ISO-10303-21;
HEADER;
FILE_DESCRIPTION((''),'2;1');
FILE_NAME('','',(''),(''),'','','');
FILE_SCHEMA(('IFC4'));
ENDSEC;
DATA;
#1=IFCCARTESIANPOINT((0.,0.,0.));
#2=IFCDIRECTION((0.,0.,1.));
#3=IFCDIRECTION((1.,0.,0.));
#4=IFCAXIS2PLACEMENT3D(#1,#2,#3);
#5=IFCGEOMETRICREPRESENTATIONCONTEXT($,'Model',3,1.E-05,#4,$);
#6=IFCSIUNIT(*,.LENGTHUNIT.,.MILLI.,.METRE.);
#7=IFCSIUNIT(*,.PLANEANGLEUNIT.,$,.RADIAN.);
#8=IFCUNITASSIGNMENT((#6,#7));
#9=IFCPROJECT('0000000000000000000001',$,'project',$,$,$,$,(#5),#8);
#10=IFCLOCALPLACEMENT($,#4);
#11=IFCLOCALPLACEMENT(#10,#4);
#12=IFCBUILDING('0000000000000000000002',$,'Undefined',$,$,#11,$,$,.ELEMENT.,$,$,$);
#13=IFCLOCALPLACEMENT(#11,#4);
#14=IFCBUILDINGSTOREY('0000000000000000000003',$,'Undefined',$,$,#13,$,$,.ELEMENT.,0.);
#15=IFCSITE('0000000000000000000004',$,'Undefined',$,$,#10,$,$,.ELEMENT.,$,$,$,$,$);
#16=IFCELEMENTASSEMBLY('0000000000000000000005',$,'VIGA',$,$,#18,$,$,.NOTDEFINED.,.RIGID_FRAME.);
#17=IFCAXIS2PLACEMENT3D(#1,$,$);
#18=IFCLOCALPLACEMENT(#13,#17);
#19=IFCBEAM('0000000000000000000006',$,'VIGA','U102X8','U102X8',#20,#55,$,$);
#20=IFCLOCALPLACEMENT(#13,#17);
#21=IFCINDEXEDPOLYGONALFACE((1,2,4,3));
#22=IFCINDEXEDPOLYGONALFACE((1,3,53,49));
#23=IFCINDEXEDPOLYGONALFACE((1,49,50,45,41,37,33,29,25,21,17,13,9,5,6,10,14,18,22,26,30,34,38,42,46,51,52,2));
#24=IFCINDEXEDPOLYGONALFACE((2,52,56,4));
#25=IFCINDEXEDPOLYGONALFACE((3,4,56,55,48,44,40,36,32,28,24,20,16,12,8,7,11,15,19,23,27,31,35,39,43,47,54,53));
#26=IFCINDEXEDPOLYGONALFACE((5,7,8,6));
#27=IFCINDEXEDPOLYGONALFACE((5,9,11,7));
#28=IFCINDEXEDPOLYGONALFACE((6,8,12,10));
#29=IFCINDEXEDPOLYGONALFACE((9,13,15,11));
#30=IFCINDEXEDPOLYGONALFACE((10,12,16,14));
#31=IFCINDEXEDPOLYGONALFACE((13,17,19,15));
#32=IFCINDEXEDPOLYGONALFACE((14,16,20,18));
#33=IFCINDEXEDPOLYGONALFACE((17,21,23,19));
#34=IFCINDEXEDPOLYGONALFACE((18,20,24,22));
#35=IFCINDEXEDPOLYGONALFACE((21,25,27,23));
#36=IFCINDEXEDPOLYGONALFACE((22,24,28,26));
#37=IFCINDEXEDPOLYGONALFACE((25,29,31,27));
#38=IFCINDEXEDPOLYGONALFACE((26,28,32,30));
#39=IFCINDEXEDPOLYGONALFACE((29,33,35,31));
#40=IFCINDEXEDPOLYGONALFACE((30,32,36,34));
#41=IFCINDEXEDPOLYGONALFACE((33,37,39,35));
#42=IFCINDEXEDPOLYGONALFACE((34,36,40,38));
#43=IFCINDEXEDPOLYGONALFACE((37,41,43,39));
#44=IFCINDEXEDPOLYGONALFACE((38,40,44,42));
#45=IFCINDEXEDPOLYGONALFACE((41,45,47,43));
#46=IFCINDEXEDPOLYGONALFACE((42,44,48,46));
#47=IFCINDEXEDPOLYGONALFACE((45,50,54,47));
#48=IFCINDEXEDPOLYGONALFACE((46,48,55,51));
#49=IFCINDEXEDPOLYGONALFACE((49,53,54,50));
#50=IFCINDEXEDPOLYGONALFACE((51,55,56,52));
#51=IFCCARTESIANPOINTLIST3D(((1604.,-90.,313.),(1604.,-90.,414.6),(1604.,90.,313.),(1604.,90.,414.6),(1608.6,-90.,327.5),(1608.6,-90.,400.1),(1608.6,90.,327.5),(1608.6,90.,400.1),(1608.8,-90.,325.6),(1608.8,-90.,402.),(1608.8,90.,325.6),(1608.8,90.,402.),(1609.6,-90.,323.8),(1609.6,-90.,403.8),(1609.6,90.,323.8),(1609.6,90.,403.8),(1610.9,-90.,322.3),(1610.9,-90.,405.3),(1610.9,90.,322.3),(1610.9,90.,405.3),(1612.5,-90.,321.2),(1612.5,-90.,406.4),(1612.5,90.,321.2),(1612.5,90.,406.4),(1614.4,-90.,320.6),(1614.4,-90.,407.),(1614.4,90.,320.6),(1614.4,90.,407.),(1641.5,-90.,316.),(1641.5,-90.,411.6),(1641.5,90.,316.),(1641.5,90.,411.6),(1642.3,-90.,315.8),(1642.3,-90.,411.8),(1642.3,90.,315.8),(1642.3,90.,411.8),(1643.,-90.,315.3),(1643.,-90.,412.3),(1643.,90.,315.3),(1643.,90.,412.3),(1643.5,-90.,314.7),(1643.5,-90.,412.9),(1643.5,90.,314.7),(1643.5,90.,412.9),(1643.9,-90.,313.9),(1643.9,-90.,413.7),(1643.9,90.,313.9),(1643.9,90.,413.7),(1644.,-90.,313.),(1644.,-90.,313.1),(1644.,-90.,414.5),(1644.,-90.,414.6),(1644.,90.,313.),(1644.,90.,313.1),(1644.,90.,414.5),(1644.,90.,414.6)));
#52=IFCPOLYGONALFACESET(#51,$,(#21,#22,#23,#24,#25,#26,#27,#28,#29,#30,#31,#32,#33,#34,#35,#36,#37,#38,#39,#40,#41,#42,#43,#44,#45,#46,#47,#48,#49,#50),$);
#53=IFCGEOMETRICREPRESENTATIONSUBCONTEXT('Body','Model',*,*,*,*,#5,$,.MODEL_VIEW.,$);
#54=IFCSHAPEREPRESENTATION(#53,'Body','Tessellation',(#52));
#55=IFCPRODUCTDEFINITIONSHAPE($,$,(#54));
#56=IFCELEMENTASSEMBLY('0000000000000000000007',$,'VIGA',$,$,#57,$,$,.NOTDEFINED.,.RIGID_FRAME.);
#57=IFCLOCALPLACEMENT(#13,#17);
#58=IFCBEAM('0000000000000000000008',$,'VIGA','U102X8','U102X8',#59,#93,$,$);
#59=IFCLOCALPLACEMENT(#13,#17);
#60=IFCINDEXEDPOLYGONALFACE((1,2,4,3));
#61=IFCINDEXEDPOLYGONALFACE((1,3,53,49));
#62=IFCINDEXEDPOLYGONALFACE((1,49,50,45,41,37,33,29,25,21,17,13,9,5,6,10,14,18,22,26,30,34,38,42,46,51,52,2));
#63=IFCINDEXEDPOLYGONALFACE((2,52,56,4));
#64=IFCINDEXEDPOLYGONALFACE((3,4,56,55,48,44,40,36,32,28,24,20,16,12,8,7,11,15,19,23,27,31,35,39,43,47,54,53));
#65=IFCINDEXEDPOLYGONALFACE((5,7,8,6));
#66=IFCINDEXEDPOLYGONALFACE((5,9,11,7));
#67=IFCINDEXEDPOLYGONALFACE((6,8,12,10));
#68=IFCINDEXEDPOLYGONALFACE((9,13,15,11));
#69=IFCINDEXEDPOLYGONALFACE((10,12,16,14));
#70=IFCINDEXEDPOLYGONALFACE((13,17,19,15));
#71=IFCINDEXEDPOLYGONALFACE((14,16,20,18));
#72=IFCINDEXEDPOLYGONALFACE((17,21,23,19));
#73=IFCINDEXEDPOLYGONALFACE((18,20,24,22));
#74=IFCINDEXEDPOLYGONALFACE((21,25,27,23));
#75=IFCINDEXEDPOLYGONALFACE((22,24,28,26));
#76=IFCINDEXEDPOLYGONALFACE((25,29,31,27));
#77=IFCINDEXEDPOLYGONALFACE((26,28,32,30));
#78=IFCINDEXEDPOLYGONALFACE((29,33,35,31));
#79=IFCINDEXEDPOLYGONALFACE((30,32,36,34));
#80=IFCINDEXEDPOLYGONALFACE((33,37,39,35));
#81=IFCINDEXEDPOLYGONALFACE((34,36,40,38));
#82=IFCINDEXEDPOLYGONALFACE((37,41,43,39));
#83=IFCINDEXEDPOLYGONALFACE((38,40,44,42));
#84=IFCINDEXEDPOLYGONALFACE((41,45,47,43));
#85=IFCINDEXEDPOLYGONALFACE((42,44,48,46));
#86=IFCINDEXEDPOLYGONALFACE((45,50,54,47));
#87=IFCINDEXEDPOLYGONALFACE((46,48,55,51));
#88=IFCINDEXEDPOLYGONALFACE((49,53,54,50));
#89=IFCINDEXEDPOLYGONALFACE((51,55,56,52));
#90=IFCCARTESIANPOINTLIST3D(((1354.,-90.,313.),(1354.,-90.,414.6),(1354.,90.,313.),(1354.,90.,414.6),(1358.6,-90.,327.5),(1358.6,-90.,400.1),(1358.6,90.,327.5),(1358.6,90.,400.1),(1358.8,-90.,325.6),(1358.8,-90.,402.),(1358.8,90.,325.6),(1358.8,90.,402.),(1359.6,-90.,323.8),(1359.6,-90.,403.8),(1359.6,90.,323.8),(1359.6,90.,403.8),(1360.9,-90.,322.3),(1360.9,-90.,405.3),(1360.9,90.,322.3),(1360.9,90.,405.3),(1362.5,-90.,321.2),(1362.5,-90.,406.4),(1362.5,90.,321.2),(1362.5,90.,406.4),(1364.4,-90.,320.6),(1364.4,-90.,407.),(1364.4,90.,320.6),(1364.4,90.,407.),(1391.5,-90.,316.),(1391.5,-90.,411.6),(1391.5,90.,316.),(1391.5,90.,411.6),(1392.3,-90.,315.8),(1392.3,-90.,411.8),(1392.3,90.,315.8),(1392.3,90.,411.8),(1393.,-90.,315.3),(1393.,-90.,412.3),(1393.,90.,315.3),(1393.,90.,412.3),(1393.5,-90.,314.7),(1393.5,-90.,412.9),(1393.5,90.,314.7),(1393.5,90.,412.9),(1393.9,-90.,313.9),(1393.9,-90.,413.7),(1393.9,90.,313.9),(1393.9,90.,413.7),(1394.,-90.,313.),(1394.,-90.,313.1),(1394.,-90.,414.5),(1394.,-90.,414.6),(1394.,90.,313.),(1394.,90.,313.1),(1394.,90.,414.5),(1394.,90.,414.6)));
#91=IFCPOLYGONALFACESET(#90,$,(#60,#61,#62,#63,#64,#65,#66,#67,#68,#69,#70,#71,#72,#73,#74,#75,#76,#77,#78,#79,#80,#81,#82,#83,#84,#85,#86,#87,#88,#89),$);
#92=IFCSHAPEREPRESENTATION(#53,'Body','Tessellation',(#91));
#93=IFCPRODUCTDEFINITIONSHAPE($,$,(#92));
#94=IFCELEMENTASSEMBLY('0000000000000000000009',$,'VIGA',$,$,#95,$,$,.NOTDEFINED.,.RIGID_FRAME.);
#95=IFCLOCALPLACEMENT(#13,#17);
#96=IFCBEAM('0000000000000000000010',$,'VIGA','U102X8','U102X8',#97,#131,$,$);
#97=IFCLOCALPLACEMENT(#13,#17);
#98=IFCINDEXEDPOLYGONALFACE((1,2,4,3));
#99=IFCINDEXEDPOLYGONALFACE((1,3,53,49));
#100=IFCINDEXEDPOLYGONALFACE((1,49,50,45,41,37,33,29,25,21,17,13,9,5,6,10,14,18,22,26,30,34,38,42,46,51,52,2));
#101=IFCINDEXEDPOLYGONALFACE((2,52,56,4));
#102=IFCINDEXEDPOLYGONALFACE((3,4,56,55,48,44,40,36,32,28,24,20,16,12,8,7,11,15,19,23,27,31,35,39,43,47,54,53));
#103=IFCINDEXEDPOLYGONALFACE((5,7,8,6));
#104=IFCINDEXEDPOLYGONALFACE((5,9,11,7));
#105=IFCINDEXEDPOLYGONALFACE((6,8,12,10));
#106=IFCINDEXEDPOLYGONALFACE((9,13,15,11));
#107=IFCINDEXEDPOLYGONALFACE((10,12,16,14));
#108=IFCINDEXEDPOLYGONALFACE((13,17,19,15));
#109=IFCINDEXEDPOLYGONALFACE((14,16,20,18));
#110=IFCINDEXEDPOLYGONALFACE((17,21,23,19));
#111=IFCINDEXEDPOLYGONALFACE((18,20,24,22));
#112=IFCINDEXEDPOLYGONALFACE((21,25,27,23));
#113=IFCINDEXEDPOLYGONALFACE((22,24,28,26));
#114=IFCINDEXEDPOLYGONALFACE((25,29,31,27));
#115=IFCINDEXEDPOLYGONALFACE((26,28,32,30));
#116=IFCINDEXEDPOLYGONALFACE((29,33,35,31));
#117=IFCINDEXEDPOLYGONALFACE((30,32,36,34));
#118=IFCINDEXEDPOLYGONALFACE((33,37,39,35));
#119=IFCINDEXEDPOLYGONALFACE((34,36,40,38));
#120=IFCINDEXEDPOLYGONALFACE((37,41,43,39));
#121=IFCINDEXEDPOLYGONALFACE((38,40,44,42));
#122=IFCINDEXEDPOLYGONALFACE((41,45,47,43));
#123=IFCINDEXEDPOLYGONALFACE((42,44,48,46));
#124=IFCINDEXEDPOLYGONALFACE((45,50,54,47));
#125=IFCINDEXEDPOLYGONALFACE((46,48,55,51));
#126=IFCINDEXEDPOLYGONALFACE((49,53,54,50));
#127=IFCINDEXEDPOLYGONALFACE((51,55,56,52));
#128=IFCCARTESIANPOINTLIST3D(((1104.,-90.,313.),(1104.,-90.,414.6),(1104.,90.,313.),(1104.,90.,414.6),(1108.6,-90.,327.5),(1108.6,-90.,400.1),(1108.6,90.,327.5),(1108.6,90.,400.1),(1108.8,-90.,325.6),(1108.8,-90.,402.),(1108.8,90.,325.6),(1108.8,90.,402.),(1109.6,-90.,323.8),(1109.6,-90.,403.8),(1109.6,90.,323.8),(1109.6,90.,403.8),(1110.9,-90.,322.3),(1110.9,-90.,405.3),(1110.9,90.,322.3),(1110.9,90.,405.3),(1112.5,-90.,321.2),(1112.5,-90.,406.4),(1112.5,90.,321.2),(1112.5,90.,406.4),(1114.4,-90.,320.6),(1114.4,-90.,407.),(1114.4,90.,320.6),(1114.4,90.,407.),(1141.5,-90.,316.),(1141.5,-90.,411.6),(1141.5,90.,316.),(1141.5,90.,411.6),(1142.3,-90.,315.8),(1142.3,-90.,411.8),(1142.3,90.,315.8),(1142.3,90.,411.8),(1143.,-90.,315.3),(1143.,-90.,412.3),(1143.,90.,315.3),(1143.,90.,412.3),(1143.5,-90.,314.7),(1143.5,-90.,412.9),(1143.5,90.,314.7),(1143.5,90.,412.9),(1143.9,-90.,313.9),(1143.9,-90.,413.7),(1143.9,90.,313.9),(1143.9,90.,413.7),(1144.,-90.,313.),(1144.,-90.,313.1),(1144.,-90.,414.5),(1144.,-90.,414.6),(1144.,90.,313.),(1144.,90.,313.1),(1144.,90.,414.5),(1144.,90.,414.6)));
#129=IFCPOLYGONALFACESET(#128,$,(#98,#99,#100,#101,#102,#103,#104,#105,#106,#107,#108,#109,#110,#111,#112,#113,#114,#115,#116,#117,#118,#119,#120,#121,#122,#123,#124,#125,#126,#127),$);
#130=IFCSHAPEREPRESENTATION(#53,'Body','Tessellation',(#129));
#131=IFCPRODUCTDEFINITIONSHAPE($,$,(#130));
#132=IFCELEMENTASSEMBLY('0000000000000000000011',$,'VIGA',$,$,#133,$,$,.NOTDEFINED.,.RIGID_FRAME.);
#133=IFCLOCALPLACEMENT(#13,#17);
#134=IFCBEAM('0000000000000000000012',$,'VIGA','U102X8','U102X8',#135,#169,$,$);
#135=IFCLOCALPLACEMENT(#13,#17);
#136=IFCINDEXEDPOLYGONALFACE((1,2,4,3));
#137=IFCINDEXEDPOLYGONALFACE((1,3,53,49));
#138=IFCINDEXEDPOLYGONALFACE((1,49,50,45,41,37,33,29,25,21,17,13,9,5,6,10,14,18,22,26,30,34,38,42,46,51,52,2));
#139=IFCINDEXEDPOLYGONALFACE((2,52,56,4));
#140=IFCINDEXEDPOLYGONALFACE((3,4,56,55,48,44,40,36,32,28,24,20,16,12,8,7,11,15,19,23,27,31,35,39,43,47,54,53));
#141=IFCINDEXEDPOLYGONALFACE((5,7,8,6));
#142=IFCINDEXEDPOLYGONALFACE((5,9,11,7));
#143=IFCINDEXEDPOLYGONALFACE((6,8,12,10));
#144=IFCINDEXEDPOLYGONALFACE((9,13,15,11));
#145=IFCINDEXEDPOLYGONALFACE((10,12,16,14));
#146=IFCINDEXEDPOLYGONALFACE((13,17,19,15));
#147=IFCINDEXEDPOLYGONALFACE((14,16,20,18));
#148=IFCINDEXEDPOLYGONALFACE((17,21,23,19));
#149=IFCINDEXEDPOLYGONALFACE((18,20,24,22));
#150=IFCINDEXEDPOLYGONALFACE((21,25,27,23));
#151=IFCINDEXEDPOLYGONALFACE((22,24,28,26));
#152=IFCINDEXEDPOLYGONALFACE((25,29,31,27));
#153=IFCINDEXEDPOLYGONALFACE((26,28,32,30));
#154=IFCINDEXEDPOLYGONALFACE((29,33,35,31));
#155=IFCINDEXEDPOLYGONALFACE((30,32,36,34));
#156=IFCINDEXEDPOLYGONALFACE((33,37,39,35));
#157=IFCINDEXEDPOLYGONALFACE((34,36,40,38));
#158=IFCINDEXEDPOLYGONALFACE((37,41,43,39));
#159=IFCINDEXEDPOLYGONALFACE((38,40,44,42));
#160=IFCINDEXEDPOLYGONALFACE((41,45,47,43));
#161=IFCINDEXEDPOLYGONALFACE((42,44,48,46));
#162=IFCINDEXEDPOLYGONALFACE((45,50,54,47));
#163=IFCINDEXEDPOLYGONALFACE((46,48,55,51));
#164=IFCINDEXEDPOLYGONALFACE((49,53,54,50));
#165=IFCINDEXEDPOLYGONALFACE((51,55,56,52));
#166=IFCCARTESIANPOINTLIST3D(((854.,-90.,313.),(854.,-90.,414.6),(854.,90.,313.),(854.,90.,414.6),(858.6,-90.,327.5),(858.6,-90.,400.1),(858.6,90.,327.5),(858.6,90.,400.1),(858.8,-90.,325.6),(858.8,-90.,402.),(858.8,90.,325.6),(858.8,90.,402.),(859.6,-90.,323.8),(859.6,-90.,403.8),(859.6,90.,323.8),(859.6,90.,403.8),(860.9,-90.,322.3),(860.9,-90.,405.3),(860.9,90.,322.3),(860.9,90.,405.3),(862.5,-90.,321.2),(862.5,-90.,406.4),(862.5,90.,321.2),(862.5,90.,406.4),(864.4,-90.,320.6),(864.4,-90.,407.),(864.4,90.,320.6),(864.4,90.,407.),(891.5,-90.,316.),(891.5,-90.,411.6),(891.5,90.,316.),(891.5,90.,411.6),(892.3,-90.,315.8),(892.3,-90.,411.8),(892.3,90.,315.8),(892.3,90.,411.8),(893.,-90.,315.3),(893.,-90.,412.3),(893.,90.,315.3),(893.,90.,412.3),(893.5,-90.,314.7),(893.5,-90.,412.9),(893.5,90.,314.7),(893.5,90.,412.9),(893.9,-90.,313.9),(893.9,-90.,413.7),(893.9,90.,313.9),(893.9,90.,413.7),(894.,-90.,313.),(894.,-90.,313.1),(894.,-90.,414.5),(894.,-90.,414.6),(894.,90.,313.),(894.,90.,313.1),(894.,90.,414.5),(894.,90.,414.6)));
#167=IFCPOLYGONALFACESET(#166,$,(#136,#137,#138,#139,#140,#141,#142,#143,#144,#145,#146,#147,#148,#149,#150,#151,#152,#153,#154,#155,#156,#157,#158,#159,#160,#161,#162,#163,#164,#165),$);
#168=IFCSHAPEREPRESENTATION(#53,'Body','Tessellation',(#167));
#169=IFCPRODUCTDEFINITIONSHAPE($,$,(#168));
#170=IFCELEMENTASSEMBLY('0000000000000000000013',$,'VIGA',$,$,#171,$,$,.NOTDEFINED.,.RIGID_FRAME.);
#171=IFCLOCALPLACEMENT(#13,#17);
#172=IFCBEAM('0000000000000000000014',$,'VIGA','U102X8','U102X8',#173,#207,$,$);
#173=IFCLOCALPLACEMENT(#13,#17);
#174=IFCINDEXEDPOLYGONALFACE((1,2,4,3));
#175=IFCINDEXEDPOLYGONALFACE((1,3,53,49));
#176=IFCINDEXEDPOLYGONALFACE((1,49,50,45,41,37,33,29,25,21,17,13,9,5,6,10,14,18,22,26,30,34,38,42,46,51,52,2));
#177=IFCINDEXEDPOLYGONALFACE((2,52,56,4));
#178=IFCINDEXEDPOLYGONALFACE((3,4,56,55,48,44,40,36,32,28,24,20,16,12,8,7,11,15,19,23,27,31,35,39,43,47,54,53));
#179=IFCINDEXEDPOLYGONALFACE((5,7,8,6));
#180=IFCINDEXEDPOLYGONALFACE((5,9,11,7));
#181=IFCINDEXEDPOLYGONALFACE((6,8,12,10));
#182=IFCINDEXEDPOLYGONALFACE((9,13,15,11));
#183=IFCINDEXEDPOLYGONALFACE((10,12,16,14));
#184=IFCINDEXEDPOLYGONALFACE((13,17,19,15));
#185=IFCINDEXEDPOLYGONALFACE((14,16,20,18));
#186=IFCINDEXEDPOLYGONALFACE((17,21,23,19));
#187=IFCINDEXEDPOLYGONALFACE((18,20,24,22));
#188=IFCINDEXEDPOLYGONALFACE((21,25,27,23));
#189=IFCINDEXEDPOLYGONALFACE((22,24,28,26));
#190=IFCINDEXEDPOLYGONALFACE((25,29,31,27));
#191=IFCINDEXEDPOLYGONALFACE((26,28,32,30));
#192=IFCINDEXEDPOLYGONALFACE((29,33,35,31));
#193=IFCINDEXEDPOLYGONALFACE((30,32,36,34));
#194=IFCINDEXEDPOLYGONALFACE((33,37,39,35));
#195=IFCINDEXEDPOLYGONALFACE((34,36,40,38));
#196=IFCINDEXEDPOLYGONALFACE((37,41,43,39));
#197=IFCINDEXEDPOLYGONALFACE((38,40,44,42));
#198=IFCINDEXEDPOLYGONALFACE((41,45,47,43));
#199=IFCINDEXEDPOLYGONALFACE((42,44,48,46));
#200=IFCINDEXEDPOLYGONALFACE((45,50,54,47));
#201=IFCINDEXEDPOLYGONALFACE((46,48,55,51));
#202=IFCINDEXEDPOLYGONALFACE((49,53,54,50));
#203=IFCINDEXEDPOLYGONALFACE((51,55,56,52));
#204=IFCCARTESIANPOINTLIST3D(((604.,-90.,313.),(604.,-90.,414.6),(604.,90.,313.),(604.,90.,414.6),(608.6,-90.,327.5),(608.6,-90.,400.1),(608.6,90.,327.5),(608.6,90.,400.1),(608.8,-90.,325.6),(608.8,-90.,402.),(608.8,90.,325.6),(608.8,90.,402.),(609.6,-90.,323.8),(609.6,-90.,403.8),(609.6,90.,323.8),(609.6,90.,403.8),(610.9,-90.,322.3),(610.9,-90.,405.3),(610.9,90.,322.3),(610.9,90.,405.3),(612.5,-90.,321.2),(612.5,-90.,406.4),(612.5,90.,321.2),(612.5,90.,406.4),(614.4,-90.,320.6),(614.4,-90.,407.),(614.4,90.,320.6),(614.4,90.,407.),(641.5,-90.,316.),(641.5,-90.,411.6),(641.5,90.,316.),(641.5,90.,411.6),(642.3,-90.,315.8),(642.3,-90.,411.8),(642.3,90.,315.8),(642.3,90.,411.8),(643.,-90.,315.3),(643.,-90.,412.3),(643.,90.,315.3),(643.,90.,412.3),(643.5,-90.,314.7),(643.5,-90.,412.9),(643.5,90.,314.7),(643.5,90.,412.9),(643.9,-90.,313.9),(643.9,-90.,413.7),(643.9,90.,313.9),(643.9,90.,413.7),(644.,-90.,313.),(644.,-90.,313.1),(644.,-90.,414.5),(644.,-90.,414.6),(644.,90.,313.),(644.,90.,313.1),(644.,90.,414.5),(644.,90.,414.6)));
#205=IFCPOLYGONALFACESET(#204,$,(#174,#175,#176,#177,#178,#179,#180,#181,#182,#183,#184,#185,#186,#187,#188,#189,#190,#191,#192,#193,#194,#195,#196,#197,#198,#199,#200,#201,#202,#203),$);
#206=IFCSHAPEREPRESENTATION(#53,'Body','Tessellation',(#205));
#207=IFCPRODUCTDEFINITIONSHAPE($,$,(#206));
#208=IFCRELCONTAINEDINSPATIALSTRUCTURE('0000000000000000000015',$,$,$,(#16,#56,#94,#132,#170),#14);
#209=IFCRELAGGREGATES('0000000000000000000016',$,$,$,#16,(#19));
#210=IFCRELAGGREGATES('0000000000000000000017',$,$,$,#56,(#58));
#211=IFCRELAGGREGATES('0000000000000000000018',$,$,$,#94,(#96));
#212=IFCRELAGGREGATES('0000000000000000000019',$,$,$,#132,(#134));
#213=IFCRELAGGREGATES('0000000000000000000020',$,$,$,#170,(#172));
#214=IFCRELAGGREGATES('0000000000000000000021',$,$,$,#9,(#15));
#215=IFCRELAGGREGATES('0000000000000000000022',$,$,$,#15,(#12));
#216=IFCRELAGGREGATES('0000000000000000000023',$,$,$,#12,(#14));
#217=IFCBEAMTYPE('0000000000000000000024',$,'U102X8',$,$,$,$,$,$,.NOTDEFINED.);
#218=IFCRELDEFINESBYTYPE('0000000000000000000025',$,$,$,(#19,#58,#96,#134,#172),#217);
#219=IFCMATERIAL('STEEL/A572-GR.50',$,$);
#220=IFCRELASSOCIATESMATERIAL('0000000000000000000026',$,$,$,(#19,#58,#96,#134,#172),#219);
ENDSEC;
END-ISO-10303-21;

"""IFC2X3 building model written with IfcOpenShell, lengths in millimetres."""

from ifc_helpers import new_model, si_unit, frame, origin_with_axes, origin_2d_with_axis, place, context, subcontext, project, spatial, u_section, extrude, material, type_object, element, aggregate, save


model = new_model("IFC2X3")

# Units and contexts
model_context = context("Model", 3, precision=1e-05, world=origin_with_axes())
body_context = subcontext(model_context, "Body", "Model", "MODEL_VIEW")
ifc_project = project(units=[si_unit("LENGTHUNIT", "METRE", prefix="MILLI"), si_unit("PLANEANGLEUNIT", "RADIAN")], contexts=[model_context])

# Site, building, storey
site_placement = place(None, origin_with_axes())
site = spatial("IfcSite", under=ifc_project, at=site_placement, Name="Undefined", CompositionType="ELEMENT")
building_placement = place(site_placement, origin_with_axes())
building = spatial("IfcBuilding", under=site, at=building_placement, Name="Undefined", CompositionType="ELEMENT")
storey_placement = place(building_placement, origin_with_axes())
storey = spatial("IfcBuildingStorey", under=building, at=storey_placement, Name="Undefined", CompositionType="ELEMENT", Elevation=0.0)

# Element assemblies, beams
ifc_material_1 = material(Name="STEEL/A572-GR.50")
beam_type_1 = type_object("IfcBeamType", Name="U102X8", PredefinedType="NOTDEFINED")
assembly_1_placement = place(storey_placement, origin_with_axes())
assembly_1 = element("IfcElementAssembly", 1, at=assembly_1_placement, inside=storey, Name="VIGA", AssemblyPlace="NOTDEFINED", PredefinedType="RIGID_FRAME")
beam_1_placement = place(assembly_1_placement, frame((1624.0, -90.0, 363.8), z_axis=(0.0, 0.0, 1.0), x_axis=(0.0, 1.0, 0.0)))
beam_1 = element("IfcBeam", 2, at=beam_1_placement, type_object=beam_type_1, material=ifc_material_1, Name="VIGA", Description="U102X8", ObjectType="U102X8", context=body_context, shape_type="SweptSolid", body=[
    extrude(u_section(Depth=101.6, FlangeWidth=40.0, WebThickness=4.6, FlangeThickness=6.0, FilletRadius=7.0, EdgeRadius=3.0, FlangeSlope=0.16839, at=origin_2d_with_axis()), frame((180.0, 0.0, 0.0), z_axis=(-1.0, 0.0, 0.0), x_axis=(0.0, -1.0, 0.0)), (0.0, 0.0, 1.0), 180.0),
])
aggregate(assembly_1, [beam_1])
assembly_2_placement = place(storey_placement, origin_with_axes())
assembly_2 = element("IfcElementAssembly", 3, at=assembly_2_placement, inside=storey, Name="VIGA", AssemblyPlace="NOTDEFINED", PredefinedType="RIGID_FRAME")
beam_2_placement = place(assembly_2_placement, frame((1374.0, -90.0, 363.8), z_axis=(0.0, 0.0, 1.0), x_axis=(0.0, 1.0, 0.0)))
beam_2 = element("IfcBeam", 4, at=beam_2_placement, type_object=beam_type_1, material=ifc_material_1, Name="VIGA", Description="U102X8", ObjectType="U102X8", context=body_context, shape_type="SweptSolid", body=[
    extrude(u_section(Depth=101.6, FlangeWidth=40.0, WebThickness=4.6, FlangeThickness=6.0, FilletRadius=7.0, EdgeRadius=3.0, FlangeSlope=0.16839, at=origin_2d_with_axis()), frame((180.0, 0.0, 0.0), z_axis=(-1.0, 0.0, 0.0), x_axis=(0.0, -1.0, 0.0)), (0.0, 0.0, 1.0), 180.0),
])
aggregate(assembly_2, [beam_2])
assembly_3_placement = place(storey_placement, origin_with_axes())
assembly_3 = element("IfcElementAssembly", 5, at=assembly_3_placement, inside=storey, Name="VIGA", AssemblyPlace="NOTDEFINED", PredefinedType="RIGID_FRAME")
beam_3_placement = place(assembly_3_placement, frame((1124.0, -90.0, 363.8), z_axis=(0.0, 0.0, 1.0), x_axis=(0.0, 1.0, 0.0)))
beam_3 = element("IfcBeam", 6, at=beam_3_placement, type_object=beam_type_1, material=ifc_material_1, Name="VIGA", Description="U102X8", ObjectType="U102X8", context=body_context, shape_type="SweptSolid", body=[
    extrude(u_section(Depth=101.6, FlangeWidth=40.0, WebThickness=4.6, FlangeThickness=6.0, FilletRadius=7.0, EdgeRadius=3.0, FlangeSlope=0.16839, at=origin_2d_with_axis()), frame((180.0, 0.0, 0.0), z_axis=(-1.0, 0.0, 0.0), x_axis=(0.0, -1.0, 0.0)), (0.0, 0.0, 1.0), 180.0),
])
aggregate(assembly_3, [beam_3])
assembly_4_placement = place(storey_placement, origin_with_axes())
assembly_4 = element("IfcElementAssembly", 7, at=assembly_4_placement, inside=storey, Name="VIGA", AssemblyPlace="NOTDEFINED", PredefinedType="RIGID_FRAME")
beam_4_placement = place(assembly_4_placement, frame((874.0, -90.0, 363.8), z_axis=(0.0, 0.0, 1.0), x_axis=(0.0, 1.0, 0.0)))
beam_4 = element("IfcBeam", 8, at=beam_4_placement, type_object=beam_type_1, material=ifc_material_1, Name="VIGA", Description="U102X8", ObjectType="U102X8", context=body_context, shape_type="SweptSolid", body=[
    extrude(u_section(Depth=101.6, FlangeWidth=40.0, WebThickness=4.6, FlangeThickness=6.0, FilletRadius=7.0, EdgeRadius=3.0, FlangeSlope=0.16839, at=origin_2d_with_axis()), frame((180.0, 0.0, 0.0), z_axis=(-1.0, 0.0, 0.0), x_axis=(0.0, -1.0, 0.0)), (0.0, 0.0, 1.0), 180.0),
])
aggregate(assembly_4, [beam_4])
assembly_5_placement = place(storey_placement, origin_with_axes())
assembly_5 = element("IfcElementAssembly", 9, at=assembly_5_placement, inside=storey, Name="VIGA", AssemblyPlace="NOTDEFINED", PredefinedType="RIGID_FRAME")
beam_5_placement = place(assembly_5_placement, frame((624.0, -90.0, 363.8), z_axis=(0.0, 0.0, 1.0), x_axis=(0.0, 1.0, 0.0)))
beam_5 = element("IfcBeam", 10, at=beam_5_placement, type_object=beam_type_1, material=ifc_material_1, Name="VIGA", Description="U102X8", ObjectType="U102X8", context=body_context, shape_type="SweptSolid", body=[
    extrude(u_section(Depth=101.6, FlangeWidth=40.0, WebThickness=4.6, FlangeThickness=6.0, FilletRadius=7.0, EdgeRadius=3.0, FlangeSlope=0.16839, at=origin_2d_with_axis()), frame((180.0, 0.0, 0.0), z_axis=(-1.0, 0.0, 0.0), x_axis=(0.0, -1.0, 0.0)), (0.0, 0.0, 1.0), 180.0),
])
aggregate(assembly_5, [beam_5])

save(model, "model.ifc")
